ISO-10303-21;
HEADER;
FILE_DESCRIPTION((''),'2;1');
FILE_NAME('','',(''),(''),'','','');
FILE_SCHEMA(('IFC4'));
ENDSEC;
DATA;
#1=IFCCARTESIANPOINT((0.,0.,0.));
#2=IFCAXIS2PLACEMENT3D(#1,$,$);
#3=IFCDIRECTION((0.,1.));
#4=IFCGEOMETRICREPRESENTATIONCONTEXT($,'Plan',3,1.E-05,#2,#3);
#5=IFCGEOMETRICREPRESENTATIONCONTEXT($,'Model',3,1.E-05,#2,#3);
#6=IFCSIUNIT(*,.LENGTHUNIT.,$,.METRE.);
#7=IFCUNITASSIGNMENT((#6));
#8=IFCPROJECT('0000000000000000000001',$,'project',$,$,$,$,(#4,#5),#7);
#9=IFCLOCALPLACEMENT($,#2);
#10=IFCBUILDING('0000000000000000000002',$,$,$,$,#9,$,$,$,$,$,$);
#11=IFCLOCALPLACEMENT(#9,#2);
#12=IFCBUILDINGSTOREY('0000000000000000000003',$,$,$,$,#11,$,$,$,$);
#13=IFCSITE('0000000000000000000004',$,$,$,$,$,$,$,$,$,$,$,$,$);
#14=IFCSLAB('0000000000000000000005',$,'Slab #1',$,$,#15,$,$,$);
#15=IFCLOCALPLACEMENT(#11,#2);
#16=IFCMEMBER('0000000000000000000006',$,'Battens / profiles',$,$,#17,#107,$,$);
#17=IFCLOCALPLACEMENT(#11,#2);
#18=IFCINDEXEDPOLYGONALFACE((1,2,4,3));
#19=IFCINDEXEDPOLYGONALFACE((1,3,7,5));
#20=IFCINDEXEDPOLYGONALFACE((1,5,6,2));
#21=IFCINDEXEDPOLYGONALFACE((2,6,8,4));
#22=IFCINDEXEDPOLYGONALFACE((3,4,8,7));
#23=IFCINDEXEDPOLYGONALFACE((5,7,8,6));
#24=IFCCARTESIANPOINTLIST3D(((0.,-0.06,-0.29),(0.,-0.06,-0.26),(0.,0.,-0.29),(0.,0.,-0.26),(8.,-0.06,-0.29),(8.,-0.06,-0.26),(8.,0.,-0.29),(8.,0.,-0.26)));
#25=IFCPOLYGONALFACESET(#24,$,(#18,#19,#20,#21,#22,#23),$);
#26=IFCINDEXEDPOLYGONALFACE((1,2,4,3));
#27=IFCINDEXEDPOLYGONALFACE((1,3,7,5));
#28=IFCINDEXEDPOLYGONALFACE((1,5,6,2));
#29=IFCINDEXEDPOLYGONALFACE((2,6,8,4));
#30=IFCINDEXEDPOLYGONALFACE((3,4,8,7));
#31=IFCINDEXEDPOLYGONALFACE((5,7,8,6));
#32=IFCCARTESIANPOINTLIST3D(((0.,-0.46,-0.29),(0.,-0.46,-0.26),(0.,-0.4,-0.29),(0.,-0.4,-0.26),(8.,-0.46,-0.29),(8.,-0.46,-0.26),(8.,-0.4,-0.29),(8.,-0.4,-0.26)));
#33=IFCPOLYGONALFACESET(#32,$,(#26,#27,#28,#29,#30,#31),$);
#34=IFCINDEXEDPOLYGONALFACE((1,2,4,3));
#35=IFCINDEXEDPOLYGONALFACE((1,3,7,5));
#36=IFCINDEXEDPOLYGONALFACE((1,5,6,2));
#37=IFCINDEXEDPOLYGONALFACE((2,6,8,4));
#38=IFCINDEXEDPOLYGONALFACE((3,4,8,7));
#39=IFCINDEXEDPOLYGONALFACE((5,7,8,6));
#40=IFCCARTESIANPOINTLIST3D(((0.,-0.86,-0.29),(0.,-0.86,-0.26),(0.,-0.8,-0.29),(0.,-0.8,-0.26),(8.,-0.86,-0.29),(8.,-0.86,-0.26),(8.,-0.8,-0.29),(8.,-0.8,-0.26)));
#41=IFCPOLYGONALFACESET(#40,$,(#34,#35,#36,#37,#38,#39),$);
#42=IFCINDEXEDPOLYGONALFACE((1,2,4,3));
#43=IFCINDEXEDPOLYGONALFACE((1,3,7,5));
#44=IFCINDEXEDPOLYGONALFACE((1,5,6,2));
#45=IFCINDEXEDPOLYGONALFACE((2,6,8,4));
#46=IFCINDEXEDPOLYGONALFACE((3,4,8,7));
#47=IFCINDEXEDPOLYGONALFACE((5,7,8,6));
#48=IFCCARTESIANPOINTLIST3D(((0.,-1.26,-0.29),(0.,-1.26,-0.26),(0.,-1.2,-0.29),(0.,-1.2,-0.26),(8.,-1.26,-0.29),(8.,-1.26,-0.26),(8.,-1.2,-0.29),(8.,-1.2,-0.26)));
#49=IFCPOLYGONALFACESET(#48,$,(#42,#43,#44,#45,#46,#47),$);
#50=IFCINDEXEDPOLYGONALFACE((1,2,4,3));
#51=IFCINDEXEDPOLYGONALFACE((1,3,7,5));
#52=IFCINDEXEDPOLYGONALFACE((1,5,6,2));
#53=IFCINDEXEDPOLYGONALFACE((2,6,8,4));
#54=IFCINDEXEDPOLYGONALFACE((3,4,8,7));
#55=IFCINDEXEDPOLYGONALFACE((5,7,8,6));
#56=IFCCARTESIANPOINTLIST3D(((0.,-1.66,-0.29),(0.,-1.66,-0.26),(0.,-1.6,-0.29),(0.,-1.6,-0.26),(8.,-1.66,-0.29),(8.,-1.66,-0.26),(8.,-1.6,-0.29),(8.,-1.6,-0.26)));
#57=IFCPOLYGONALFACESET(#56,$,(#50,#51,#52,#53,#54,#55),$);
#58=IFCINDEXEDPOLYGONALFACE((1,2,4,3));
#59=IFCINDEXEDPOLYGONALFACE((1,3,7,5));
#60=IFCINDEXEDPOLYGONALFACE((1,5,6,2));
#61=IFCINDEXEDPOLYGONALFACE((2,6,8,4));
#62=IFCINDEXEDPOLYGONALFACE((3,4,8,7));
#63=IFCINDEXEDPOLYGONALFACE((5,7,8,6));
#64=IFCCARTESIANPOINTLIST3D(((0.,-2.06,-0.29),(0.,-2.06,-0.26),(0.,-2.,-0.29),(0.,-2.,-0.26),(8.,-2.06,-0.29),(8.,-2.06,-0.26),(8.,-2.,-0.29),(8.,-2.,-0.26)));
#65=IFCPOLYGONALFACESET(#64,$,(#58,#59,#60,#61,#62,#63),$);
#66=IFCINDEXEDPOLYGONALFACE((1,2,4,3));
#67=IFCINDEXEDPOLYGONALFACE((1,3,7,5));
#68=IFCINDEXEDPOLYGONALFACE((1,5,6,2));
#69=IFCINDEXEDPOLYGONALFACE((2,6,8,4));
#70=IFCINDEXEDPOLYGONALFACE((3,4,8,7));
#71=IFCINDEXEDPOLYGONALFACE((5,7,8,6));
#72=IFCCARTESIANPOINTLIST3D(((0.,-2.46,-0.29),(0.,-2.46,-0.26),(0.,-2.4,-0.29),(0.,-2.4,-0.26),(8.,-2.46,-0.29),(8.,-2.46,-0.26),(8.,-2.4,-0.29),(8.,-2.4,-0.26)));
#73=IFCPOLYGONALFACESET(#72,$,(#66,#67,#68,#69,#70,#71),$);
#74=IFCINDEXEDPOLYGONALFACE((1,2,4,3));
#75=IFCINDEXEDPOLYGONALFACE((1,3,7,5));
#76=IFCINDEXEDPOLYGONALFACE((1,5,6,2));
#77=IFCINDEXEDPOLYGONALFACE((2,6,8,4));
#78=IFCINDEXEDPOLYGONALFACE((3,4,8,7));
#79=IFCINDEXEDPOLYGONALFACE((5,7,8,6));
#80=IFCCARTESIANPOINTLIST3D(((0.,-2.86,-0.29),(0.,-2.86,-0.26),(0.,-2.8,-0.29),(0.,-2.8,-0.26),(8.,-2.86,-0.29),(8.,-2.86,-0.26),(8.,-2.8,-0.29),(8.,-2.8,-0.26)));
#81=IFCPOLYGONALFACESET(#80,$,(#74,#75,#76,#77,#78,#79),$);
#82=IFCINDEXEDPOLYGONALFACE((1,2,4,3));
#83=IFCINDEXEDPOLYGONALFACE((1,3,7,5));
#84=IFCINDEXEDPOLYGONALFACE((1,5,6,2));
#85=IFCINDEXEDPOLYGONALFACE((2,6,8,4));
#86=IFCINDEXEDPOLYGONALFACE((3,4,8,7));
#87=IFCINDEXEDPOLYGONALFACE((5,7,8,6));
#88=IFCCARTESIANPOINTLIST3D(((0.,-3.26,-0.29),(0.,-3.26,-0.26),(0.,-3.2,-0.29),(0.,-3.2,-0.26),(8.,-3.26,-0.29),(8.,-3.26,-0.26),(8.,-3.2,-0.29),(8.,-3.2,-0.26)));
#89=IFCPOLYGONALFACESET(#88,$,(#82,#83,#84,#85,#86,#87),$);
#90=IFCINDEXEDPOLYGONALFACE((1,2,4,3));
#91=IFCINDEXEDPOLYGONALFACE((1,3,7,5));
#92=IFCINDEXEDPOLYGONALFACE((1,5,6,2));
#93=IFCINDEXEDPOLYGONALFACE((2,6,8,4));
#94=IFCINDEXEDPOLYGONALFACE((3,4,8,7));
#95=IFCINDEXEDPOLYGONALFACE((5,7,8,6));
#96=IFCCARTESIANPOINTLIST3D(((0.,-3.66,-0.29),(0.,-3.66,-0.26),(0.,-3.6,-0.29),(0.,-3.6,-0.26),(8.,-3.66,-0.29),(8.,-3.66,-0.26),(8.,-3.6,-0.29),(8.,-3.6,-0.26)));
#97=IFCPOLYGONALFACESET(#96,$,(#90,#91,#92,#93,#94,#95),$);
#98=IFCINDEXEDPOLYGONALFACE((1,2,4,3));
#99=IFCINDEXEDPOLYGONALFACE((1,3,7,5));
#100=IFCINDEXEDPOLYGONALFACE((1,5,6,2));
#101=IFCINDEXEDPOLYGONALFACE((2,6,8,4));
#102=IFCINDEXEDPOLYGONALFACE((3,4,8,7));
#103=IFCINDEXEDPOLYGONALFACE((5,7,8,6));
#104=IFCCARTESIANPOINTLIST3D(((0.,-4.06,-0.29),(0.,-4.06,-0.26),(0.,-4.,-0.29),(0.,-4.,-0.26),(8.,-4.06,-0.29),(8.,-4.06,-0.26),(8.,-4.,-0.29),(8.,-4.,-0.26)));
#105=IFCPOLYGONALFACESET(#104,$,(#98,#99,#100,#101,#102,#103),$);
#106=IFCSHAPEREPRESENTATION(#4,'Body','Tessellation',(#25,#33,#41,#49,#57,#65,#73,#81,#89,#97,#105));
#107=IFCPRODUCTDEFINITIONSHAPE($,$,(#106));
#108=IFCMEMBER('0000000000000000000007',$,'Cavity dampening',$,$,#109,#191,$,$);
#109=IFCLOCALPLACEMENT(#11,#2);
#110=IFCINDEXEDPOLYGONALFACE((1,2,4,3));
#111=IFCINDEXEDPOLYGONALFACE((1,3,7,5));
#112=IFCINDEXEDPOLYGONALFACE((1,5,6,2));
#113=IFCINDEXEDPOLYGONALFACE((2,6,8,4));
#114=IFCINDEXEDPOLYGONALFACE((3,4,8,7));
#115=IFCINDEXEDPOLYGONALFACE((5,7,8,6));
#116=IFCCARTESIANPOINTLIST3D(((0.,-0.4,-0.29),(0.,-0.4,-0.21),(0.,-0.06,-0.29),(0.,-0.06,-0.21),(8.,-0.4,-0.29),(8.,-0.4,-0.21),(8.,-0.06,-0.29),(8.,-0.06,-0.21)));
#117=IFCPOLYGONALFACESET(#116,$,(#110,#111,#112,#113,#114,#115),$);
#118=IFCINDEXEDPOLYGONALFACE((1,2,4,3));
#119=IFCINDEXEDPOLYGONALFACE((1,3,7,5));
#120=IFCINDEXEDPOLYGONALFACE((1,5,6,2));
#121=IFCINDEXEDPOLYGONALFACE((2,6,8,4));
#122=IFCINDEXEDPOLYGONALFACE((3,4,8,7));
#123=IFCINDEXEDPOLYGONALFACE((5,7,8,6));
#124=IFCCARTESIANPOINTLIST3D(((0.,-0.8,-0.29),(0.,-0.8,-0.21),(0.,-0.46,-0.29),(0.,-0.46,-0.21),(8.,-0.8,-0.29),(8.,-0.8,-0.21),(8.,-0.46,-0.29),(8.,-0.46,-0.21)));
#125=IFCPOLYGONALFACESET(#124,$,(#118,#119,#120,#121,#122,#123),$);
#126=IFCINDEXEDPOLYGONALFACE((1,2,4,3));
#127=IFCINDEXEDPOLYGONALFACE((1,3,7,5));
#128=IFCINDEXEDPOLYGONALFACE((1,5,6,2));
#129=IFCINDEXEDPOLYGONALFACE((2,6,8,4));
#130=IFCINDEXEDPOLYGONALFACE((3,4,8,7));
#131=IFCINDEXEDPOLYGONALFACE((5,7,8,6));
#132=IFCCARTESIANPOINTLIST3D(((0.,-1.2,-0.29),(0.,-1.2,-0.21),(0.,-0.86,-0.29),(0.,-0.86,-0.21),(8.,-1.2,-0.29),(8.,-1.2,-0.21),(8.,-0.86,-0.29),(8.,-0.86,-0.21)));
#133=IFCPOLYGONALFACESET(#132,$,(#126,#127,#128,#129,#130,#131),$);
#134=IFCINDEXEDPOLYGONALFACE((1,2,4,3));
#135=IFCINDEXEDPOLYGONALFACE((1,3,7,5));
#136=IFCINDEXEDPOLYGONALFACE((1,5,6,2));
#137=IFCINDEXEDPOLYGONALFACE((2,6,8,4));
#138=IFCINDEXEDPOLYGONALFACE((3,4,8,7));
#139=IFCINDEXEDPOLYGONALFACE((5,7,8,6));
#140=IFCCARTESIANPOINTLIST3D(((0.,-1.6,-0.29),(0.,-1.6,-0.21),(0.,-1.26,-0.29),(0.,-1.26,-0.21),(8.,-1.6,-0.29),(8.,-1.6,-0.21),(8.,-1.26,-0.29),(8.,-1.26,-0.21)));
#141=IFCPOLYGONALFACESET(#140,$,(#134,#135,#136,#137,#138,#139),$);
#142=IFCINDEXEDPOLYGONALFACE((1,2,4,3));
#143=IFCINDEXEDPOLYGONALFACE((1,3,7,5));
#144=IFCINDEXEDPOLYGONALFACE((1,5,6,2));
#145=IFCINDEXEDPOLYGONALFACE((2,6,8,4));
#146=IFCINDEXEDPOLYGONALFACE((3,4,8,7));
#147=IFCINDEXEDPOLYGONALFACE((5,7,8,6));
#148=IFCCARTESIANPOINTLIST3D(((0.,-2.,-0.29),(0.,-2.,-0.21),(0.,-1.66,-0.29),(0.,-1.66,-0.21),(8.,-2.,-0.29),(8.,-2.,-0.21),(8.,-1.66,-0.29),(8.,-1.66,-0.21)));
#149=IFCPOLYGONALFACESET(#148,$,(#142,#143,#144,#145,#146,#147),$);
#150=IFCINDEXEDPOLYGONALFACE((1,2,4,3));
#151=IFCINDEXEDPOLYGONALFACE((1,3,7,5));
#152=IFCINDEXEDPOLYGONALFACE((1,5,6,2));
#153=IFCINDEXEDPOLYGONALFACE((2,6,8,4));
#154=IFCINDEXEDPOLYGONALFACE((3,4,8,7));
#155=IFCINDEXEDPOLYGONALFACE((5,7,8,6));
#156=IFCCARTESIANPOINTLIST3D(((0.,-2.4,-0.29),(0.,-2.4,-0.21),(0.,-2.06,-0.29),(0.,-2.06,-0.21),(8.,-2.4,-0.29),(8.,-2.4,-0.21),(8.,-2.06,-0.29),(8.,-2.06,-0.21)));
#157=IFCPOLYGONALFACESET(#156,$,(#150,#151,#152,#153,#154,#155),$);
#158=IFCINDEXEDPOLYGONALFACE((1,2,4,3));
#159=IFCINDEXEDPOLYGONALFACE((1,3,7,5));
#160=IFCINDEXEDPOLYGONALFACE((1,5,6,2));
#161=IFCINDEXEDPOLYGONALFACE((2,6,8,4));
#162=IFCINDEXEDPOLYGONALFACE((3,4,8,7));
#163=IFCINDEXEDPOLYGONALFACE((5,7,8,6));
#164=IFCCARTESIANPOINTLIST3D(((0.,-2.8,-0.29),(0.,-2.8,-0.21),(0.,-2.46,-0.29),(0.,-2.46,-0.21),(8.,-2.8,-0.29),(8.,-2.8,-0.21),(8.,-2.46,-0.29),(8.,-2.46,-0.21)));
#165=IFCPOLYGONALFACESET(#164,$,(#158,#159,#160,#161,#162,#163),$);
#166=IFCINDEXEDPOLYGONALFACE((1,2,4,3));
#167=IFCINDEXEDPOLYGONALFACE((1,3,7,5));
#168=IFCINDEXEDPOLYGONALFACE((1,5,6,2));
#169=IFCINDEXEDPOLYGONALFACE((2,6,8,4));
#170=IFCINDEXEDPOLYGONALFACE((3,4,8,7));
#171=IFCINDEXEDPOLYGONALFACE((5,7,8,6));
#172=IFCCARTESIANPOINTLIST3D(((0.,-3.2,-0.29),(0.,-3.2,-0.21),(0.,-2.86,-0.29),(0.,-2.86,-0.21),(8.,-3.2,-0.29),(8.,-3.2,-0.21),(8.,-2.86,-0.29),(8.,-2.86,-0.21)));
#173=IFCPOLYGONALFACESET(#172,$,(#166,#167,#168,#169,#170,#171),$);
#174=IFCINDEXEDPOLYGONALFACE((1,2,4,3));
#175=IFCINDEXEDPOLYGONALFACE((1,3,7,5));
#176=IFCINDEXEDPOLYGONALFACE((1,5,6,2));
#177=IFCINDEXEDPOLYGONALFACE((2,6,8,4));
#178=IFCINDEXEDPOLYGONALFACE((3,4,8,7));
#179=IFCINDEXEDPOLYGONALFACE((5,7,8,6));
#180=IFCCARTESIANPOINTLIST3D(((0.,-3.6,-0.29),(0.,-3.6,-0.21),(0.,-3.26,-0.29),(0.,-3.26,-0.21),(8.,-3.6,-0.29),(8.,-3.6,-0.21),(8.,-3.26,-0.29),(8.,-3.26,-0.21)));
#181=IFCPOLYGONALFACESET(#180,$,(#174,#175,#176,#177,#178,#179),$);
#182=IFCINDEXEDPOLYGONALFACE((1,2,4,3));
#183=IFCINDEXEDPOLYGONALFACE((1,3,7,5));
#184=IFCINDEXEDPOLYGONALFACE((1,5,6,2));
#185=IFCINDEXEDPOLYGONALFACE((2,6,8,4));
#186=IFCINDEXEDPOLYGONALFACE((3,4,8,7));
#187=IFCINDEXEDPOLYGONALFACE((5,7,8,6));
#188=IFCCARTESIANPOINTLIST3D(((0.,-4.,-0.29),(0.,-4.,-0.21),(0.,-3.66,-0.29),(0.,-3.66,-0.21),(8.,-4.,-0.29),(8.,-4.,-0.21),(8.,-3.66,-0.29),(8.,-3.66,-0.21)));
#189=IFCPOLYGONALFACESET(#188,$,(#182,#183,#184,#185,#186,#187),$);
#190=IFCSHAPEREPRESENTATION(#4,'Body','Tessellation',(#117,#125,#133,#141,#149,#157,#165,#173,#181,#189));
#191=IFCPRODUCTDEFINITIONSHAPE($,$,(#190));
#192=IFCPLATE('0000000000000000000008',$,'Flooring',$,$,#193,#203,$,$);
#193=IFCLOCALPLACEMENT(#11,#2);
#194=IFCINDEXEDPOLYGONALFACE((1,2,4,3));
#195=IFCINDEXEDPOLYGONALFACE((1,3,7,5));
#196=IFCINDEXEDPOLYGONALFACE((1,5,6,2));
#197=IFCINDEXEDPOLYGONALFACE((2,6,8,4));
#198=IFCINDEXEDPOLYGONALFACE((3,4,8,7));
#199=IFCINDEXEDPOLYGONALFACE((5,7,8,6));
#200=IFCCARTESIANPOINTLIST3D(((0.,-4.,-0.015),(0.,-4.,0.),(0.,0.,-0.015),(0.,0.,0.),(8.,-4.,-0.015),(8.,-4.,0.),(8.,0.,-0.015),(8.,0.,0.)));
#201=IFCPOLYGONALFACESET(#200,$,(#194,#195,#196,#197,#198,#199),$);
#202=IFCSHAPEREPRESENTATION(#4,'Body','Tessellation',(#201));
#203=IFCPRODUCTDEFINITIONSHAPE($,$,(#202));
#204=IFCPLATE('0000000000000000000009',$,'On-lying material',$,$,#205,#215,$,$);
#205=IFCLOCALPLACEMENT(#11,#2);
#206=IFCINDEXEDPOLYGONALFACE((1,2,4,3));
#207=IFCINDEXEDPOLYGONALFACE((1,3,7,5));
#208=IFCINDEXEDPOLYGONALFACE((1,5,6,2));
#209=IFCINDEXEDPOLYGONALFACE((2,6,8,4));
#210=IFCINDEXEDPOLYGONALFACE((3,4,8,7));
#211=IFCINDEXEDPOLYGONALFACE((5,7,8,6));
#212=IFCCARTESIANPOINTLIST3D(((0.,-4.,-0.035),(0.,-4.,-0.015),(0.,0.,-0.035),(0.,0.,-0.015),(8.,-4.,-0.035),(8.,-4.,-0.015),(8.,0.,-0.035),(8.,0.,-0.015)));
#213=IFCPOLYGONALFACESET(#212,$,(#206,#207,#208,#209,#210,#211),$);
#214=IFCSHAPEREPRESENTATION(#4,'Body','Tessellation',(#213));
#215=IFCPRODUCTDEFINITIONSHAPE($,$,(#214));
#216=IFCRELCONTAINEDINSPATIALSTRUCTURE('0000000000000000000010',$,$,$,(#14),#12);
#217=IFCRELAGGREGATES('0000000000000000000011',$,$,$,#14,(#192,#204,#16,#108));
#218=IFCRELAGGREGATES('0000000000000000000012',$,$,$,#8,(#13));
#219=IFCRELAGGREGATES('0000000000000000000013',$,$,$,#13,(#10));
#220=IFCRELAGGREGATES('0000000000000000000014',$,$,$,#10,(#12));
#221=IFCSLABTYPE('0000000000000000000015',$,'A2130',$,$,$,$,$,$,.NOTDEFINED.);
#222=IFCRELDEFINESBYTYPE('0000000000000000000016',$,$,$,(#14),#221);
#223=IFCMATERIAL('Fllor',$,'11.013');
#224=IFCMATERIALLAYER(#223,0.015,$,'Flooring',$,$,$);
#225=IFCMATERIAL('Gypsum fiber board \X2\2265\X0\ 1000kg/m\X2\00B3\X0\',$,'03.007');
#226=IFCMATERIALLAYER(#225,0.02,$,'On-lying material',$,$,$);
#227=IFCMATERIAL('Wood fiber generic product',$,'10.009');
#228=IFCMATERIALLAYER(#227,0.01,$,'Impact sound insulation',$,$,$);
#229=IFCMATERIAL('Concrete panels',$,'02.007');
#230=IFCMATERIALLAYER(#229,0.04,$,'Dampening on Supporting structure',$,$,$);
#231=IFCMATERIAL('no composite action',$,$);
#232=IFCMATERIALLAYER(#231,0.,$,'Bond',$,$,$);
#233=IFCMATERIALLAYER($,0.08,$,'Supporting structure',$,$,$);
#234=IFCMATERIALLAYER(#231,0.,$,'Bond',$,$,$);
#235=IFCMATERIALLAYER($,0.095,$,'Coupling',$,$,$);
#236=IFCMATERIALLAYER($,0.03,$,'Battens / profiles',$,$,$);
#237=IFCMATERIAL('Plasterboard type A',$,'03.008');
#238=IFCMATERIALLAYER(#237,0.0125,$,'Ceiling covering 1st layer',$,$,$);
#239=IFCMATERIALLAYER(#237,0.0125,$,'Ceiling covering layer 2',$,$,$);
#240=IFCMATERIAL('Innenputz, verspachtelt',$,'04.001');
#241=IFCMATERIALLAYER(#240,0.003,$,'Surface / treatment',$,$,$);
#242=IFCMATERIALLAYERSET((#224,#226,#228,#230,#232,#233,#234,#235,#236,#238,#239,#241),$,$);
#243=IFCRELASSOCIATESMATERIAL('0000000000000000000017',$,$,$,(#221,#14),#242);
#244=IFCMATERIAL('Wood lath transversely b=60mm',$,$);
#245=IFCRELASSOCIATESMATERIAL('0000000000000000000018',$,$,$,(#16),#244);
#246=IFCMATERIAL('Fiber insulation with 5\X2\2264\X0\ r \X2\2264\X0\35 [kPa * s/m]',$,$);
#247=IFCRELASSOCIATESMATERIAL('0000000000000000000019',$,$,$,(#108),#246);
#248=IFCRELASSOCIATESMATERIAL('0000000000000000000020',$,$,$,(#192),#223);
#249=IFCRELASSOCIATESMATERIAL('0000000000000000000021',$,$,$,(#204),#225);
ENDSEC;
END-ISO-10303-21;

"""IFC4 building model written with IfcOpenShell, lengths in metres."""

from ifc_helpers import new_model, si_unit, direction, frame, frame_2d, origin, origin_with_axes, place, context, project, spatial, rectangle, extrude, material, layer, layer_set, type_object, element, aggregate, save


model = new_model("IFC4")

# Units and contexts
plan_context = context("Plan", 3, precision=1e-05, world=origin(), true_north=direction((0.0, 1.0)))
model_context = context("Model", 3, precision=1e-05, world=origin(), true_north=direction((0.0, 1.0)))
ifc_project = project(units=[si_unit("LENGTHUNIT", "METRE")], contexts=[plan_context, model_context])

# Site, building, storey
site = spatial("IfcSite", under=ifc_project)
building_placement = place(None, origin())
building = spatial("IfcBuilding", under=site, at=building_placement)
storey_placement = place(building_placement, origin())
storey = spatial("IfcBuildingStorey", under=building, at=storey_placement)

# Slab, members, plates
ifc_material_1 = material(Name="Fllor", Category="11.013")
ifc_layer_1 = layer(ifc_material_1, 0.015, Name="Flooring")
ifc_material_2 = material(Name="Gypsum fiber board ≥ 1000kg/m³", Category="03.007")
ifc_layer_2 = layer(ifc_material_2, 0.02, Name="On-lying material")
ifc_material_3 = material(Name="Wood fiber generic product", Category="10.009")
ifc_layer_3 = layer(ifc_material_3, 0.01, Name="Impact sound insulation")
ifc_material_4 = material(Name="Concrete panels", Category="02.007")
ifc_layer_4 = layer(ifc_material_4, 0.04, Name="Dampening on Supporting structure")
ifc_material_5 = material(Name="no composite action")
ifc_layer_5 = layer(ifc_material_5, 0.0, Name="Bond")
ifc_layer_6 = layer(None, 0.08, Name="Supporting structure")
ifc_layer_7 = layer(ifc_material_5, 0.0, Name="Bond")
ifc_layer_8 = layer(None, 0.095, Name="Coupling")
ifc_layer_9 = layer(None, 0.03, Name="Battens / profiles")
ifc_material_6 = material(Name="Plasterboard type A", Category="03.008")
ifc_layer_10 = layer(ifc_material_6, 0.0125, Name="Ceiling covering 1st layer")
ifc_layer_11 = layer(ifc_material_6, 0.0125, Name="Ceiling covering layer 2")
ifc_material_7 = material(Name="Innenputz, verspachtelt", Category="04.001")
ifc_layer_12 = layer(ifc_material_7, 0.003, Name="Surface / treatment")
ifc_layer_set = layer_set([ifc_layer_1, ifc_layer_2, ifc_layer_3, ifc_layer_4, ifc_layer_5, ifc_layer_6, ifc_layer_7, ifc_layer_8, ifc_layer_9, ifc_layer_10, ifc_layer_11, ifc_layer_12])
slab_type = type_object("IfcSlabType", Name="A2130", PredefinedType="NOTDEFINED", material=ifc_layer_set)
slab_placement = place(None, frame((0.0, 0.0, 0.0), z_axis=(0.0, 0.0, -1.0), x_axis=(1.0, 0.0, 0.0)))
slab = element("IfcSlab", 1, at=slab_placement, inside=storey, type_object=slab_type, material=ifc_layer_set, Name="Slab #1")
ifc_material_8 = material(Name="Wood lath transversely b=60mm")
member_1_placement = place(slab_placement, origin())
member_1 = element("IfcMember", 2, at=member_1_placement, material=ifc_material_8, Name="Battens / profiles", context=plan_context, shape_type="SweptSolid", body=[
    extrude(rectangle(XDim=0.06, YDim=0.03, at=frame_2d((0.03, 0.015), x_axis=(1.0, 0.0))), frame((0.0, 0.0, 0.26), z_axis=(1.0, 0.0, 0.0), x_axis=(0.0, 1.0, 0.0)), (0.0, 0.0, 1.0), 8.0),
    extrude(rectangle(XDim=0.06, YDim=0.03, at=frame_2d((0.03, 0.015), x_axis=(1.0, 0.0))), frame((0.0, 0.4, 0.26), z_axis=(1.0, 0.0, 0.0), x_axis=(0.0, 1.0, 0.0)), (0.0, 0.0, 1.0), 8.0),
    extrude(rectangle(XDim=0.06, YDim=0.03, at=frame_2d((0.03, 0.015), x_axis=(1.0, 0.0))), frame((0.0, 0.8, 0.26), z_axis=(1.0, 0.0, 0.0), x_axis=(0.0, 1.0, 0.0)), (0.0, 0.0, 1.0), 8.0),
    extrude(rectangle(XDim=0.06, YDim=0.03, at=frame_2d((0.03, 0.015), x_axis=(1.0, 0.0))), frame((0.0, 1.2, 0.26), z_axis=(1.0, 0.0, 0.0), x_axis=(0.0, 1.0, 0.0)), (0.0, 0.0, 1.0), 8.0),
    extrude(rectangle(XDim=0.06, YDim=0.03, at=frame_2d((0.03, 0.015), x_axis=(1.0, 0.0))), frame((0.0, 1.6, 0.26), z_axis=(1.0, 0.0, 0.0), x_axis=(0.0, 1.0, 0.0)), (0.0, 0.0, 1.0), 8.0),
    extrude(rectangle(XDim=0.06, YDim=0.03, at=frame_2d((0.03, 0.015), x_axis=(1.0, 0.0))), frame((0.0, 2.0, 0.26), z_axis=(1.0, 0.0, 0.0), x_axis=(0.0, 1.0, 0.0)), (0.0, 0.0, 1.0), 8.0),
    extrude(rectangle(XDim=0.06, YDim=0.03, at=frame_2d((0.03, 0.015), x_axis=(1.0, 0.0))), frame((0.0, 2.4, 0.26), z_axis=(1.0, 0.0, 0.0), x_axis=(0.0, 1.0, 0.0)), (0.0, 0.0, 1.0), 8.0),
    extrude(rectangle(XDim=0.06, YDim=0.03, at=frame_2d((0.03, 0.015), x_axis=(1.0, 0.0))), frame((0.0, 2.8, 0.26), z_axis=(1.0, 0.0, 0.0), x_axis=(0.0, 1.0, 0.0)), (0.0, 0.0, 1.0), 8.0),
    extrude(rectangle(XDim=0.06, YDim=0.03, at=frame_2d((0.03, 0.015), x_axis=(1.0, 0.0))), frame((0.0, 3.2, 0.26), z_axis=(1.0, 0.0, 0.0), x_axis=(0.0, 1.0, 0.0)), (0.0, 0.0, 1.0), 8.0),
    extrude(rectangle(XDim=0.06, YDim=0.03, at=frame_2d((0.03, 0.015), x_axis=(1.0, 0.0))), frame((0.0, 3.6, 0.26), z_axis=(1.0, 0.0, 0.0), x_axis=(0.0, 1.0, 0.0)), (0.0, 0.0, 1.0), 8.0),
    extrude(rectangle(XDim=0.06, YDim=0.03, at=frame_2d((0.03, 0.015), x_axis=(1.0, 0.0))), frame((0.0, 4.0, 0.26), z_axis=(1.0, 0.0, 0.0), x_axis=(0.0, 1.0, 0.0)), (0.0, 0.0, 1.0), 8.0),
])
ifc_material_9 = material(Name="Fiber insulation with 5≤ r ≤35 [kPa * s/m]")
member_2_placement = place(slab_placement, origin())
member_2 = element("IfcMember", 3, at=member_2_placement, material=ifc_material_9, Name="Cavity dampening", context=plan_context, shape_type="SweptSolid", body=[
    extrude(rectangle(XDim=0.34, YDim=0.08, at=frame_2d((0.17, 0.04), x_axis=(1.0, 0.0))), frame((0.0, 0.06, 0.21), z_axis=(1.0, 0.0, 0.0), x_axis=(0.0, 1.0, 0.0)), (0.0, 0.0, 1.0), 8.0),
    extrude(rectangle(XDim=0.34, YDim=0.08, at=frame_2d((0.17, 0.04), x_axis=(1.0, 0.0))), frame((0.0, 0.46, 0.21), z_axis=(1.0, 0.0, 0.0), x_axis=(0.0, 1.0, 0.0)), (0.0, 0.0, 1.0), 8.0),
    extrude(rectangle(XDim=0.34, YDim=0.08, at=frame_2d((0.17, 0.04), x_axis=(1.0, 0.0))), frame((0.0, 0.86, 0.21), z_axis=(1.0, 0.0, 0.0), x_axis=(0.0, 1.0, 0.0)), (0.0, 0.0, 1.0), 8.0),
    extrude(rectangle(XDim=0.34, YDim=0.08, at=frame_2d((0.17, 0.04), x_axis=(1.0, 0.0))), frame((0.0, 1.26, 0.21), z_axis=(1.0, 0.0, 0.0), x_axis=(0.0, 1.0, 0.0)), (0.0, 0.0, 1.0), 8.0),
    extrude(rectangle(XDim=0.34, YDim=0.08, at=frame_2d((0.17, 0.04), x_axis=(1.0, 0.0))), frame((0.0, 1.66, 0.21), z_axis=(1.0, 0.0, 0.0), x_axis=(0.0, 1.0, 0.0)), (0.0, 0.0, 1.0), 8.0),
    extrude(rectangle(XDim=0.34, YDim=0.08, at=frame_2d((0.17, 0.04), x_axis=(1.0, 0.0))), frame((0.0, 2.06, 0.21), z_axis=(1.0, 0.0, 0.0), x_axis=(0.0, 1.0, 0.0)), (0.0, 0.0, 1.0), 8.0),
    extrude(rectangle(XDim=0.34, YDim=0.08, at=frame_2d((0.17, 0.04), x_axis=(1.0, 0.0))), frame((0.0, 2.46, 0.21), z_axis=(1.0, 0.0, 0.0), x_axis=(0.0, 1.0, 0.0)), (0.0, 0.0, 1.0), 8.0),
    extrude(rectangle(XDim=0.34, YDim=0.08, at=frame_2d((0.17, 0.04), x_axis=(1.0, 0.0))), frame((0.0, 2.86, 0.21), z_axis=(1.0, 0.0, 0.0), x_axis=(0.0, 1.0, 0.0)), (0.0, 0.0, 1.0), 8.0),
    extrude(rectangle(XDim=0.34, YDim=0.08, at=frame_2d((0.17, 0.04), x_axis=(1.0, 0.0))), frame((0.0, 3.26, 0.21), z_axis=(1.0, 0.0, 0.0), x_axis=(0.0, 1.0, 0.0)), (0.0, 0.0, 1.0), 8.0),
    extrude(rectangle(XDim=0.34, YDim=0.08, at=frame_2d((0.17, 0.04), x_axis=(1.0, 0.0))), frame((0.0, 3.66, 0.21), z_axis=(1.0, 0.0, 0.0), x_axis=(0.0, 1.0, 0.0)), (0.0, 0.0, 1.0), 8.0),
])
plate_1_placement = place(slab_placement, origin())
plate_1 = element("IfcPlate", 4, at=plate_1_placement, material=ifc_material_1, Name="Flooring", context=plan_context, shape_type="SweptSolid", body=[
    extrude(rectangle(XDim=8.0, YDim=4.0, at=frame_2d((4.0, 2.0), x_axis=(1.0, 0.0))), origin_with_axes(), (0.0, 0.0, 1.0), 0.015),
])
plate_2_placement = place(slab_placement, origin())
plate_2 = element("IfcPlate", 5, at=plate_2_placement, material=ifc_material_2, Name="On-lying material", context=plan_context, shape_type="SweptSolid", body=[
    extrude(rectangle(XDim=8.0, YDim=4.0, at=frame_2d((4.0, 2.0), x_axis=(1.0, 0.0))), frame((0.0, 0.0, 0.015), z_axis=(0.0, 0.0, 1.0), x_axis=(1.0, 0.0, 0.0)), (0.0, 0.0, 1.0), 0.02),
])
aggregate(slab, [plate_1, plate_2, member_1, member_2])

save(model, "model.ifc")
